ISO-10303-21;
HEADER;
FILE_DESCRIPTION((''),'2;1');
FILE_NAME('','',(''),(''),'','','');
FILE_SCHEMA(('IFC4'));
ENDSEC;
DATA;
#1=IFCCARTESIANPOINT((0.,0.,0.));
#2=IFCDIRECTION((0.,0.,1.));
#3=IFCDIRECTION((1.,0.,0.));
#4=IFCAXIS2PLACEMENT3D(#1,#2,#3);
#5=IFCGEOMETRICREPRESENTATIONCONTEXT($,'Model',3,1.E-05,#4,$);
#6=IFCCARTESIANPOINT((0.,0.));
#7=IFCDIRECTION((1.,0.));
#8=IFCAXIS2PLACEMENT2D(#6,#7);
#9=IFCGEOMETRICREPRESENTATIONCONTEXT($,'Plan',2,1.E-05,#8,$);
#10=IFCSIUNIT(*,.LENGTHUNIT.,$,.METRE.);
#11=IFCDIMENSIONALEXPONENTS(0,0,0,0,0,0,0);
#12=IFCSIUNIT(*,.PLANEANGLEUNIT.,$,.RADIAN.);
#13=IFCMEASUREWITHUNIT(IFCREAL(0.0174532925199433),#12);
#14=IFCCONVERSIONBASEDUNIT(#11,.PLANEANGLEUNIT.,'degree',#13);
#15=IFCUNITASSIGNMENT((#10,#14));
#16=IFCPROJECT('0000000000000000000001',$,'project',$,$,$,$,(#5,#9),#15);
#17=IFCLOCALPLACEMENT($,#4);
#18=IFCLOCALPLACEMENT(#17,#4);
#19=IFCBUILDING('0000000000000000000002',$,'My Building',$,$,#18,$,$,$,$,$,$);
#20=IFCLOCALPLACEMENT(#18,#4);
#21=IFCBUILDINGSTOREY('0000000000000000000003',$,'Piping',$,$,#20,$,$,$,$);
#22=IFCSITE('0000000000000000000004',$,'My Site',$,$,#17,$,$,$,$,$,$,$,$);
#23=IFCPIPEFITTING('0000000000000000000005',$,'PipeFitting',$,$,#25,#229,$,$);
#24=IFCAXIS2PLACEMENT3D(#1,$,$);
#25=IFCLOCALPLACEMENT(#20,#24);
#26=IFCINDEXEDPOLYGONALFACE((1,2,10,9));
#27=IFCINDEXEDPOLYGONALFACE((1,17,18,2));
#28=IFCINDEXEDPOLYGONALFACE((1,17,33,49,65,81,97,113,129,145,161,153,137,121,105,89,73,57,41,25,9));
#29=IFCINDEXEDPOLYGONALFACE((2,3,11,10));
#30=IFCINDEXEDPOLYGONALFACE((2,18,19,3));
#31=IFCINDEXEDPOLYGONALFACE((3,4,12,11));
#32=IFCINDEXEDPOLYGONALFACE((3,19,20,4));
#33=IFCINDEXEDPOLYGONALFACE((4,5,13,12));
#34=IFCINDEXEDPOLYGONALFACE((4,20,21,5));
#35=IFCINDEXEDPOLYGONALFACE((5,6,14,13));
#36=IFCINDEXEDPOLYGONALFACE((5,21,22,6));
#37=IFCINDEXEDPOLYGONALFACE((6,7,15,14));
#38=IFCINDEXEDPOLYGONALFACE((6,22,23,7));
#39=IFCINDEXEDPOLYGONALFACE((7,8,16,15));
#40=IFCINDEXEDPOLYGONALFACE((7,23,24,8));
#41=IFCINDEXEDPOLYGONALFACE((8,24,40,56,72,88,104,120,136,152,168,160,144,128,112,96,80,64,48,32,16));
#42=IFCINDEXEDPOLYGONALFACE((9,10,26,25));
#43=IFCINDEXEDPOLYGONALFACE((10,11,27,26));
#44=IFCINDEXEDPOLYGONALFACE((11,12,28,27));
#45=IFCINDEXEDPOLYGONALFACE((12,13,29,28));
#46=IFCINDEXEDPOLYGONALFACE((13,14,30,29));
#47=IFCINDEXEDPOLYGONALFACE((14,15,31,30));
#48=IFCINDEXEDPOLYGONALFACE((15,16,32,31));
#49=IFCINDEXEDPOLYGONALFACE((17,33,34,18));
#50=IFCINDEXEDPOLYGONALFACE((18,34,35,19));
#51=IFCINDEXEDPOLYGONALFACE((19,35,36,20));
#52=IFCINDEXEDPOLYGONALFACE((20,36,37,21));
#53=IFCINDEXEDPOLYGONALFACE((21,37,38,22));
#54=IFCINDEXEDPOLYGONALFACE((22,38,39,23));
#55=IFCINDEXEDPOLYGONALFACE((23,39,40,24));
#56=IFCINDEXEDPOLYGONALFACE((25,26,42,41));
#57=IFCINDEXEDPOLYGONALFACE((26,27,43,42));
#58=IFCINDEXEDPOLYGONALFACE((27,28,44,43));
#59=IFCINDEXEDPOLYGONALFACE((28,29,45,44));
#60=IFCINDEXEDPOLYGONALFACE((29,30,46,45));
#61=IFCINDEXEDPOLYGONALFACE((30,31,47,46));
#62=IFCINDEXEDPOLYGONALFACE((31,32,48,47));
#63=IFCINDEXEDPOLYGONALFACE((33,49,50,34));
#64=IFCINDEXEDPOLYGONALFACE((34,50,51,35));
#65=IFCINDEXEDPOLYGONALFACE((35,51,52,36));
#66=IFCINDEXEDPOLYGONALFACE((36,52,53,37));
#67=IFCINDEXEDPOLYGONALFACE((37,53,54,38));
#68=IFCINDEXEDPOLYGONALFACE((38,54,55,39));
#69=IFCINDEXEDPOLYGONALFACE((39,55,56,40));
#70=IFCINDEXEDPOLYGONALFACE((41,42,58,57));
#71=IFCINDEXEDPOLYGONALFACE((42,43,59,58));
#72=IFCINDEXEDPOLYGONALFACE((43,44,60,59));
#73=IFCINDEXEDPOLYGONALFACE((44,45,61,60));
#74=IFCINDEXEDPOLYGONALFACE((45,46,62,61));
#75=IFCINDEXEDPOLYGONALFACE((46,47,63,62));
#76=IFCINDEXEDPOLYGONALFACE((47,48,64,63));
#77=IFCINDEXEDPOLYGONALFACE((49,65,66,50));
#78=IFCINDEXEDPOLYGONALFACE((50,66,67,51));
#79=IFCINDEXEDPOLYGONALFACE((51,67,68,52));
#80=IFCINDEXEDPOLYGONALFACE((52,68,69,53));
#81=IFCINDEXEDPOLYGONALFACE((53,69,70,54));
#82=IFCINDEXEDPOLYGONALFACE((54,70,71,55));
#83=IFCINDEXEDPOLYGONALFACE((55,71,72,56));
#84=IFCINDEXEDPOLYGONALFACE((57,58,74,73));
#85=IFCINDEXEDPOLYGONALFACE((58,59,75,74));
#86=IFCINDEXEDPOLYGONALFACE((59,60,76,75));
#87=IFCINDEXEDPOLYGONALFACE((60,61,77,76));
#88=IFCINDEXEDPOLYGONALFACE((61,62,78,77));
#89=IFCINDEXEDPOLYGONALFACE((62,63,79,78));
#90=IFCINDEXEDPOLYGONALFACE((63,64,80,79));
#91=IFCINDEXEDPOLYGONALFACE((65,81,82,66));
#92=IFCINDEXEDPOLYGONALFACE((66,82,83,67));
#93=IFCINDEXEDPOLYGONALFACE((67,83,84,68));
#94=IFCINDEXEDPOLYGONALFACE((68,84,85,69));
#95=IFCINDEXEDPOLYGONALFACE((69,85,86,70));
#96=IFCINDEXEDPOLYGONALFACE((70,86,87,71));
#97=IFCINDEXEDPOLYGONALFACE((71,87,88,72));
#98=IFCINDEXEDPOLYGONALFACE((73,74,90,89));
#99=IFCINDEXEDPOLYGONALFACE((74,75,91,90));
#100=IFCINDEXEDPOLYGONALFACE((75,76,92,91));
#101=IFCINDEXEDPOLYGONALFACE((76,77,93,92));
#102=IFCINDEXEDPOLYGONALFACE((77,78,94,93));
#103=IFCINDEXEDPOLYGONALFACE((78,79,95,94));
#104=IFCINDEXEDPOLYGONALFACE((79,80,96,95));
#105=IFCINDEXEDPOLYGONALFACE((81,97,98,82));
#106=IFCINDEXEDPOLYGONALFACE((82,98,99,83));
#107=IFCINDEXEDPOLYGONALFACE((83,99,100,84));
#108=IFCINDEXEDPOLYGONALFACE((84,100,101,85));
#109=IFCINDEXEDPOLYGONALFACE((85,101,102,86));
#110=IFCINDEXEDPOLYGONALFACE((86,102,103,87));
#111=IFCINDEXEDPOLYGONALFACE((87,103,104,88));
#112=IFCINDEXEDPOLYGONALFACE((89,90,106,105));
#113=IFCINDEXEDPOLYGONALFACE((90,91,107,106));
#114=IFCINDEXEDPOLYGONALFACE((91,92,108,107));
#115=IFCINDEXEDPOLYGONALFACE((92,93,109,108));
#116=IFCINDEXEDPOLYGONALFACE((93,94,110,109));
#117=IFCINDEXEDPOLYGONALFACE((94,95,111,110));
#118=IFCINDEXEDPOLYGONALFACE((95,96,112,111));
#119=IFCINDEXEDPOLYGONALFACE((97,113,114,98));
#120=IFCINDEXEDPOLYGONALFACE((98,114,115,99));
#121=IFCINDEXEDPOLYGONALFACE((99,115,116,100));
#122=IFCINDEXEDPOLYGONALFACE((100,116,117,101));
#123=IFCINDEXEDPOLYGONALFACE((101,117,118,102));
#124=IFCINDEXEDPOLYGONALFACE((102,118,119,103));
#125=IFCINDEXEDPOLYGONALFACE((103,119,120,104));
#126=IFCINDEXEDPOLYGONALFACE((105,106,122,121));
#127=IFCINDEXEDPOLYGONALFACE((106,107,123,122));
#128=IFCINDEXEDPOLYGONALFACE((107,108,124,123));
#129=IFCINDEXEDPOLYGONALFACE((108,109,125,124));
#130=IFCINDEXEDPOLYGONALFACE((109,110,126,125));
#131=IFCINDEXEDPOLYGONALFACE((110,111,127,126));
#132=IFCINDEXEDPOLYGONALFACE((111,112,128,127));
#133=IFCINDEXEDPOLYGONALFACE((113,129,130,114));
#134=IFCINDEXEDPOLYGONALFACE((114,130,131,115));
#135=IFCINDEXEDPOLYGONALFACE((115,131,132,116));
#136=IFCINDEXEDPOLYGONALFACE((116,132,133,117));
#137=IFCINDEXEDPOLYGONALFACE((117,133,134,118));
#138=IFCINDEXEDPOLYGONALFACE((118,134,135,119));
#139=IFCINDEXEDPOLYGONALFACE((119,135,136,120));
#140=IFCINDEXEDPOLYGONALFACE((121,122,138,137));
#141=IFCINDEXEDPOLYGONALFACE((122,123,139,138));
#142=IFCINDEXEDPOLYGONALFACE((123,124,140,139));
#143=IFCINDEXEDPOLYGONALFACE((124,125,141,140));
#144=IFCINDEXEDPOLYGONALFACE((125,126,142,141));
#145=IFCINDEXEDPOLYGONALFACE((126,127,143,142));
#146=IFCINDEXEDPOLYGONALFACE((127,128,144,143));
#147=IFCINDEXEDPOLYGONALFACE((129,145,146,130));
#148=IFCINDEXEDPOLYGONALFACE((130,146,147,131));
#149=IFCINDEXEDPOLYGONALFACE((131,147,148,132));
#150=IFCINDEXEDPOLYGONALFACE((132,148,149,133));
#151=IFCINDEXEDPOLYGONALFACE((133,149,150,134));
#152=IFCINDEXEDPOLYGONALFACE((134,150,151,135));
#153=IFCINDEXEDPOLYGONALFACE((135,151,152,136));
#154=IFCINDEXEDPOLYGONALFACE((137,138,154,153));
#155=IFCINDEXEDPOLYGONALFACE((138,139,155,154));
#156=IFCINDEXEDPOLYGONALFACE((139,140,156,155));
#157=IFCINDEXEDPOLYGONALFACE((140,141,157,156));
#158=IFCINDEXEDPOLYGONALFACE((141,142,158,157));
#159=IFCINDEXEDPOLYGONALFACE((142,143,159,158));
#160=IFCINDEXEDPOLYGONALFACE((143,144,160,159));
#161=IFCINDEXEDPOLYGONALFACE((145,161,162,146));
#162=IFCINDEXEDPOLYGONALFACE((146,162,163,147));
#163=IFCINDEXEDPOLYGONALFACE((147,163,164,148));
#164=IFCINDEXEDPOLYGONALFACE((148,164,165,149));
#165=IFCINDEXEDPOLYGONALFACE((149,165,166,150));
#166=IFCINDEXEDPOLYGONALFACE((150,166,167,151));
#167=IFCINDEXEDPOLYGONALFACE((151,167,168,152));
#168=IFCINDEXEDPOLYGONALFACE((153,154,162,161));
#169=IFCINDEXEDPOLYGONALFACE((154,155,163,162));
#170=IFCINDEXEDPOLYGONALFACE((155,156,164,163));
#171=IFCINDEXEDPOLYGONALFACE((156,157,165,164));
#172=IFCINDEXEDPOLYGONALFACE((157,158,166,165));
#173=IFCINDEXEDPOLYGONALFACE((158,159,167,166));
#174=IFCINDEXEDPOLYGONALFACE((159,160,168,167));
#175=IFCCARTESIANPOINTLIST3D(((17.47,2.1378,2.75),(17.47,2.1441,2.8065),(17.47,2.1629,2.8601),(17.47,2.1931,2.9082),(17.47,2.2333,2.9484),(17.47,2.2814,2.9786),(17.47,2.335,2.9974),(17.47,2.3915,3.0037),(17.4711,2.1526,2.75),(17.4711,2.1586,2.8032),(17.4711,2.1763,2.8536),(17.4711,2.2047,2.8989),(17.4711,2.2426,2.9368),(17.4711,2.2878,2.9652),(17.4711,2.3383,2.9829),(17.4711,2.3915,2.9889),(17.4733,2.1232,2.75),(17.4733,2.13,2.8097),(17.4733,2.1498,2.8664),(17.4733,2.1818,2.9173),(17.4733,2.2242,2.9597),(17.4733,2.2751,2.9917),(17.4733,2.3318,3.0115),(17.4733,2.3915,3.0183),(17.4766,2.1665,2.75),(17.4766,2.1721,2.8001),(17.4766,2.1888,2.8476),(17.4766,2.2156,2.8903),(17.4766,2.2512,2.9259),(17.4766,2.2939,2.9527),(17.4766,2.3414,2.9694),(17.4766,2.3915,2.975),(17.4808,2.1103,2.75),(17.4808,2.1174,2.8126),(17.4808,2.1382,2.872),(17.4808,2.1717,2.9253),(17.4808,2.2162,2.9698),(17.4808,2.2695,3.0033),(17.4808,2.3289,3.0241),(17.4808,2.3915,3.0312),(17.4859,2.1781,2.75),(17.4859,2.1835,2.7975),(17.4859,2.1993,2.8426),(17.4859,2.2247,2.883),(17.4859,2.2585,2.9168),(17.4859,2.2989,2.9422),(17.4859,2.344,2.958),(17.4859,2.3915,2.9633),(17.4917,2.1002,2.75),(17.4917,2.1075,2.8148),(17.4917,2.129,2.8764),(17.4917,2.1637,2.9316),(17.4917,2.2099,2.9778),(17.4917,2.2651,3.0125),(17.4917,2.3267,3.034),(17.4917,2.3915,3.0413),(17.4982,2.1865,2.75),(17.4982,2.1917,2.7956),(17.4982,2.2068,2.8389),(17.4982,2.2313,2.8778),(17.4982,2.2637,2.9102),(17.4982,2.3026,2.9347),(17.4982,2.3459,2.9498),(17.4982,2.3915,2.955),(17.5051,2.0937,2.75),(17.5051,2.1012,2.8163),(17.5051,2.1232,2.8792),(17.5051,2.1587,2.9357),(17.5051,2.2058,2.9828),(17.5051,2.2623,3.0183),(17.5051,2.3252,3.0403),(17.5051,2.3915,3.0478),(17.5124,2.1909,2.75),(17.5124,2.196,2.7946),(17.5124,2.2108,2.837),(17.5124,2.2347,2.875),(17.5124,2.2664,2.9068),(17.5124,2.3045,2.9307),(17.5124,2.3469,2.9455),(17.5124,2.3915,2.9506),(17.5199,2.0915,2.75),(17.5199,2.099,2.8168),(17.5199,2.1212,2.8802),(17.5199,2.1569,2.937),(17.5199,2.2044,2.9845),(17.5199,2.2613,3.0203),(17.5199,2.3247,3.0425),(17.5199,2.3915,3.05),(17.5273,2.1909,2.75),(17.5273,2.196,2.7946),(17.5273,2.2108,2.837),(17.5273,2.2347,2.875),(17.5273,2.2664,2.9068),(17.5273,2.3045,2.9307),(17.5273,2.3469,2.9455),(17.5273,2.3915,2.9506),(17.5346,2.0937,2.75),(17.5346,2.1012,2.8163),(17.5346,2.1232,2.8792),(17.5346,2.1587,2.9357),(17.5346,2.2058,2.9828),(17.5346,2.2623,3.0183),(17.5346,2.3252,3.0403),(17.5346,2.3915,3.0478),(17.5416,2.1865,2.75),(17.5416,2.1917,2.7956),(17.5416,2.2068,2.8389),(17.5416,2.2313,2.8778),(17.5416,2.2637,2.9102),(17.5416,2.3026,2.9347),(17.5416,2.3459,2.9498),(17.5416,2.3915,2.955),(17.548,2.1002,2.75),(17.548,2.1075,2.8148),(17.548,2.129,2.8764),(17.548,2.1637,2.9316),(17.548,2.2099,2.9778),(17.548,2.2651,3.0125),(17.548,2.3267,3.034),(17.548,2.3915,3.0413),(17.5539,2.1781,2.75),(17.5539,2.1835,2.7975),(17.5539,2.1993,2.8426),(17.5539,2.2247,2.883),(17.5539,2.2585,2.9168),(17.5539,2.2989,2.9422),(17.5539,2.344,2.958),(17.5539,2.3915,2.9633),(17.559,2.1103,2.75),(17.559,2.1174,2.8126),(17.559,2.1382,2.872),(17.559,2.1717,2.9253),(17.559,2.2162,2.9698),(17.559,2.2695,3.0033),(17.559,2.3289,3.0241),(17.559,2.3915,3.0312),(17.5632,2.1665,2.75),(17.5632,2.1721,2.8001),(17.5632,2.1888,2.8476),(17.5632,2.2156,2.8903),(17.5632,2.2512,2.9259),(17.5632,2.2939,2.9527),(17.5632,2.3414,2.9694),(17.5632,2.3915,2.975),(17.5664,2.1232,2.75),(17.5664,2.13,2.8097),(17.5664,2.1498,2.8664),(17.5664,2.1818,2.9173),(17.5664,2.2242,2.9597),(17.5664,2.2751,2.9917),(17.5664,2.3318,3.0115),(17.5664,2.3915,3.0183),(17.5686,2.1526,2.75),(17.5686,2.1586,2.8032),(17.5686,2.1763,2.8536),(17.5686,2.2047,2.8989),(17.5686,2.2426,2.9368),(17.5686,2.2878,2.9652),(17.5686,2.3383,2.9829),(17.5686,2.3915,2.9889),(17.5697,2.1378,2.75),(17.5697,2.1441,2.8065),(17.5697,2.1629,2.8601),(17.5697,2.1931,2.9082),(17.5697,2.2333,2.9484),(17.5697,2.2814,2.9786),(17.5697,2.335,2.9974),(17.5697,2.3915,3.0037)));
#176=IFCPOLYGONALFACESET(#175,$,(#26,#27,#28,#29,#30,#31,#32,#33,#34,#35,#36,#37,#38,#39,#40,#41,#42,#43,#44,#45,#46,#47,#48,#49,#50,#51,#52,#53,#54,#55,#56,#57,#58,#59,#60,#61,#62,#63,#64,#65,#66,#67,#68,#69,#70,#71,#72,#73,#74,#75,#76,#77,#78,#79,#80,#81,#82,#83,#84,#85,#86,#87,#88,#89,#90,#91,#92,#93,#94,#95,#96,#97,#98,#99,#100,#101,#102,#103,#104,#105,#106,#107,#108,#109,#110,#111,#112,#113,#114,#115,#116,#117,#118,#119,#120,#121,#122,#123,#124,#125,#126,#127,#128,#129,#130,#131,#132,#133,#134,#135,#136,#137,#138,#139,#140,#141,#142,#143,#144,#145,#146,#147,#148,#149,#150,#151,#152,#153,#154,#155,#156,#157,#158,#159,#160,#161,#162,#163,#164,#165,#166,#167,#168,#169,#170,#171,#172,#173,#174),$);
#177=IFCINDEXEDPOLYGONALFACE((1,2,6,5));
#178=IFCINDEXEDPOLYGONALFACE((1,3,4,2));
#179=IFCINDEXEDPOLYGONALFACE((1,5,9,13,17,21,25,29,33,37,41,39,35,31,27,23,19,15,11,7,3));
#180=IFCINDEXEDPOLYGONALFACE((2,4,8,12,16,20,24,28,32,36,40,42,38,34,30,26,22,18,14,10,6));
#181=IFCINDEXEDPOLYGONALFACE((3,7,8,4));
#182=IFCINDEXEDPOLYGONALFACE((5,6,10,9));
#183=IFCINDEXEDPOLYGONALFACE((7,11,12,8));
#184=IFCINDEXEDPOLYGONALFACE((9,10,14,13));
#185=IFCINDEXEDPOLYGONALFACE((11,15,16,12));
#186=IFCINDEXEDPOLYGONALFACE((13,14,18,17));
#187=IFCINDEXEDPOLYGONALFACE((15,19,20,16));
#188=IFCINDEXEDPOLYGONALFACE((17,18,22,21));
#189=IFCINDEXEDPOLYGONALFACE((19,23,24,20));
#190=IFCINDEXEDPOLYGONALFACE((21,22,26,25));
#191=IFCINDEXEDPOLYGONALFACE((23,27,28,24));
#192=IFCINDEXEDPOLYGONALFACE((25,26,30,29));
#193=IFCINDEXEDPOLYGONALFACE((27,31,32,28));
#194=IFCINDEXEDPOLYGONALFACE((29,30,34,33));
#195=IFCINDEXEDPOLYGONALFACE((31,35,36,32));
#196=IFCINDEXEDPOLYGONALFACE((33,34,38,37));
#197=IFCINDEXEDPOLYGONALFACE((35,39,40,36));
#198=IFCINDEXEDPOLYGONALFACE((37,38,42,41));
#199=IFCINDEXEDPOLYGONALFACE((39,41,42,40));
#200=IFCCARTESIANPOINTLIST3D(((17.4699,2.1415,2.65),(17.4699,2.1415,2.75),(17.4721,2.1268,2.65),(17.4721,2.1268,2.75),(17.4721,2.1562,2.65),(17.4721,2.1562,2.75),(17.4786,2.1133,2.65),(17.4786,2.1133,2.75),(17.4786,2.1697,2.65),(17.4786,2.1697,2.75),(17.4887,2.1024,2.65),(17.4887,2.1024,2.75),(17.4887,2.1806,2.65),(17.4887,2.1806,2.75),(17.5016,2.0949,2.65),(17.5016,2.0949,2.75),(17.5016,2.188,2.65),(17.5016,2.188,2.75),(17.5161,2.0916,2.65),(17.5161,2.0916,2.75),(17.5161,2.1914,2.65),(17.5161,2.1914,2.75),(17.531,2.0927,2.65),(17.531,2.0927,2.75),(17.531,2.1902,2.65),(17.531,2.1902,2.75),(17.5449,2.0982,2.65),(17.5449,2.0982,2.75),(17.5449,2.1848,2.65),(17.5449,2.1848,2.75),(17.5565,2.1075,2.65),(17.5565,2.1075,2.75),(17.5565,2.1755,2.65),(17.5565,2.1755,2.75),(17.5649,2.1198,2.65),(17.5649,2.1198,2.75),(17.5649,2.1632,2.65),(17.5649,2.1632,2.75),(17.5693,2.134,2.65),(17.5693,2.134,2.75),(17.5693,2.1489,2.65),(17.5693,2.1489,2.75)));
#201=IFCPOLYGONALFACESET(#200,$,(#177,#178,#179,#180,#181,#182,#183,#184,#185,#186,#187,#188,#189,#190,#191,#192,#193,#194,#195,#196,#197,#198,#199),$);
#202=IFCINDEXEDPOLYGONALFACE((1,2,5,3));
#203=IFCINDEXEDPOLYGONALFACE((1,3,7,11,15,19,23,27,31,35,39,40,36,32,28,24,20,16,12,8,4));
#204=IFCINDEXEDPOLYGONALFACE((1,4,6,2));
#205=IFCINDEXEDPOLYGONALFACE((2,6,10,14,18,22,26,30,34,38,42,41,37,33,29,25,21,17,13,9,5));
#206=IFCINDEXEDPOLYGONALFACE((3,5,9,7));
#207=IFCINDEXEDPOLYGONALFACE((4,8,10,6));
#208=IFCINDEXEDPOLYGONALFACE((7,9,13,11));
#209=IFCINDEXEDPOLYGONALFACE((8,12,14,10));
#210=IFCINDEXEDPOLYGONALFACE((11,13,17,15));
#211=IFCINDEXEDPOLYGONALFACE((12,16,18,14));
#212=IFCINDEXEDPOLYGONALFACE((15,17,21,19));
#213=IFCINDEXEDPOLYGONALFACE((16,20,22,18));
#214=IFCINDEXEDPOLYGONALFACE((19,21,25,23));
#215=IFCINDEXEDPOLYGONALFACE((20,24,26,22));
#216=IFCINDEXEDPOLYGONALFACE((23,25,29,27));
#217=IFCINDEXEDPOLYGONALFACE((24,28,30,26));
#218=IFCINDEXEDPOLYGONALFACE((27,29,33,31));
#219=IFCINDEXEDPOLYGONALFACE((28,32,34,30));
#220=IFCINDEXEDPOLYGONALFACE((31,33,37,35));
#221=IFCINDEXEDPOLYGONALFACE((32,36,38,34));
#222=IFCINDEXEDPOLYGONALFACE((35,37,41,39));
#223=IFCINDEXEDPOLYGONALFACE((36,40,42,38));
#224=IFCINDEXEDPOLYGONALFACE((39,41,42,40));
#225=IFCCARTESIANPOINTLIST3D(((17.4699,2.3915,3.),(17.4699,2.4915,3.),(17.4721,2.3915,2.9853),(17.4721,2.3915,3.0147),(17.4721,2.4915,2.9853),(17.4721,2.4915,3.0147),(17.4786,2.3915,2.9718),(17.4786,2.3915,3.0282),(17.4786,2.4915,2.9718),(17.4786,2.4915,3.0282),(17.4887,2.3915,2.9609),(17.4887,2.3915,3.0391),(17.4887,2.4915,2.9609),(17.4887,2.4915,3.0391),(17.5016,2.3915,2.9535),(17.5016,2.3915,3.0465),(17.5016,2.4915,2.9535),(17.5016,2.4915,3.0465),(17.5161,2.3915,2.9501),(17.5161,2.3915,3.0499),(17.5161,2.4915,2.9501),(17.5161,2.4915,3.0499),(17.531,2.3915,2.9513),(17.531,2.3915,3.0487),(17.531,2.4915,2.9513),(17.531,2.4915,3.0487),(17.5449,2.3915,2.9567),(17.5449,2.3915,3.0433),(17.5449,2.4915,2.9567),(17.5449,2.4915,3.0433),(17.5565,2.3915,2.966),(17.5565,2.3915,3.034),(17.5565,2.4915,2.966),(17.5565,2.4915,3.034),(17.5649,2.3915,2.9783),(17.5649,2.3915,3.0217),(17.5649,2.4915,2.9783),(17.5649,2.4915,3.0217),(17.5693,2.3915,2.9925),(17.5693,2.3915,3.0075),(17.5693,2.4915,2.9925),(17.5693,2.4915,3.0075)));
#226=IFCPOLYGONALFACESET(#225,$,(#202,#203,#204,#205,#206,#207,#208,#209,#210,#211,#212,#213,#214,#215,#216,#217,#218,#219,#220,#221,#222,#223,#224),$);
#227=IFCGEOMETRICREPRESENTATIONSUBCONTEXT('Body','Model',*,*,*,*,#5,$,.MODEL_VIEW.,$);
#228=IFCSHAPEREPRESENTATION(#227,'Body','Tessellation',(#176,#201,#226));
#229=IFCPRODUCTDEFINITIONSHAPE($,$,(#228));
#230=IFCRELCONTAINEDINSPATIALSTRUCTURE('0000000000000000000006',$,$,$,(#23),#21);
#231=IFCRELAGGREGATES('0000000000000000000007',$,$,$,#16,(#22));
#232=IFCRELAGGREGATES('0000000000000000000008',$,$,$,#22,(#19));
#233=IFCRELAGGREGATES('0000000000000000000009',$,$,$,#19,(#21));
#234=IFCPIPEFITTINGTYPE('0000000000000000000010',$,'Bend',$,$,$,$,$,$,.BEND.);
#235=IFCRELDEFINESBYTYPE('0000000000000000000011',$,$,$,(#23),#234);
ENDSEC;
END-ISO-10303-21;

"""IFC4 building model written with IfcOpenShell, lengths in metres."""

from ifc_helpers import new_model, entity, si_unit, converted_unit, frame, origin_with_axes, origin_2d_with_axis, place, context, subcontext, project, spatial, circle, extrude, source, transform, mapped, type_object, type_shapes, element, save


model = new_model("IFC4")

# Units and contexts
model_context = context("Model", 3, precision=1e-05, world=origin_with_axes())
plan_context = context("Plan", 2, precision=1e-05, world=origin_2d_with_axis())
body_context = subcontext(model_context, "Body", "Model", "MODEL_VIEW")
ifc_project = project(units=[si_unit("LENGTHUNIT", "METRE"), converted_unit("PLANEANGLEUNIT", "degree", entity("IfcReal", 0.0174532925199433), si_unit("PLANEANGLEUNIT", "RADIAN"), dimensions=[0, 0, 0, 0, 0, 0, 0])], contexts=[model_context, plan_context])

# Site, building, storey
site_placement = place(None, origin_with_axes())
site = spatial("IfcSite", under=ifc_project, at=site_placement, Name="My Site")
building_placement = place(site_placement, origin_with_axes())
building = spatial("IfcBuilding", under=site, at=building_placement, Name="My Building")
storey_placement = place(building_placement, origin_with_axes())
storey = spatial("IfcBuildingStorey", under=building, at=storey_placement, Name="Piping")

# Pipe fitting
pipe_fitting_type_1 = type_object("IfcPipeFittingType", Name="Bend", PredefinedType="BEND")
shared_shape = source(origin_with_axes(), body_context, "Body", "SolidModel", [
    entity("IfcSweptDiskSolid", entity("IfcIndexedPolyCurve", entity("IfcCartesianPointList3D", [[0.0, 0.0, -0.1], [0.0, 0.0732, -0.2768], [0.0, 0.25, -0.35]]), [entity("IfcArcIndex", [1, 2, 3])]), 0.05),
    extrude(circle(Radius=0.05), origin_with_axes(), (0.0, 0.0, -1.0), 0.1),
    extrude(circle(Radius=0.05), frame((0.0, 0.25, -0.35), z_axis=(0.0, 1.0, 0.0), x_axis=(1.0, 0.0, 0.0)), (0.0, 0.0, 1.0), 0.1),
])
type_shapes(pipe_fitting_type_1, [shared_shape])
for number, where, z_axis, x_axis, name in (
    (1, (17.5199, 2.1415, 2.65), (0.0, 0.0, -1.0), (-1.0, 0.0, 0.0), "PipeFitting"),
):
    element("IfcPipeFitting", number, at=place(storey_placement, frame(where, z_axis=z_axis, x_axis=x_axis)), inside=storey, type_object=pipe_fitting_type_1, Name=name, context=body_context, shape_type="MappedRepresentation", body=[
        mapped(shared_shape, transform((0.0, 0.0, 0.0), x_axis=(1.0, 0.0, 0.0), y_axis=(0.0, 1.0, 0.0), z_axis=(0.0, 0.0, 1.0), scale=1.0)),
    ])

save(model, "model.ifc")
